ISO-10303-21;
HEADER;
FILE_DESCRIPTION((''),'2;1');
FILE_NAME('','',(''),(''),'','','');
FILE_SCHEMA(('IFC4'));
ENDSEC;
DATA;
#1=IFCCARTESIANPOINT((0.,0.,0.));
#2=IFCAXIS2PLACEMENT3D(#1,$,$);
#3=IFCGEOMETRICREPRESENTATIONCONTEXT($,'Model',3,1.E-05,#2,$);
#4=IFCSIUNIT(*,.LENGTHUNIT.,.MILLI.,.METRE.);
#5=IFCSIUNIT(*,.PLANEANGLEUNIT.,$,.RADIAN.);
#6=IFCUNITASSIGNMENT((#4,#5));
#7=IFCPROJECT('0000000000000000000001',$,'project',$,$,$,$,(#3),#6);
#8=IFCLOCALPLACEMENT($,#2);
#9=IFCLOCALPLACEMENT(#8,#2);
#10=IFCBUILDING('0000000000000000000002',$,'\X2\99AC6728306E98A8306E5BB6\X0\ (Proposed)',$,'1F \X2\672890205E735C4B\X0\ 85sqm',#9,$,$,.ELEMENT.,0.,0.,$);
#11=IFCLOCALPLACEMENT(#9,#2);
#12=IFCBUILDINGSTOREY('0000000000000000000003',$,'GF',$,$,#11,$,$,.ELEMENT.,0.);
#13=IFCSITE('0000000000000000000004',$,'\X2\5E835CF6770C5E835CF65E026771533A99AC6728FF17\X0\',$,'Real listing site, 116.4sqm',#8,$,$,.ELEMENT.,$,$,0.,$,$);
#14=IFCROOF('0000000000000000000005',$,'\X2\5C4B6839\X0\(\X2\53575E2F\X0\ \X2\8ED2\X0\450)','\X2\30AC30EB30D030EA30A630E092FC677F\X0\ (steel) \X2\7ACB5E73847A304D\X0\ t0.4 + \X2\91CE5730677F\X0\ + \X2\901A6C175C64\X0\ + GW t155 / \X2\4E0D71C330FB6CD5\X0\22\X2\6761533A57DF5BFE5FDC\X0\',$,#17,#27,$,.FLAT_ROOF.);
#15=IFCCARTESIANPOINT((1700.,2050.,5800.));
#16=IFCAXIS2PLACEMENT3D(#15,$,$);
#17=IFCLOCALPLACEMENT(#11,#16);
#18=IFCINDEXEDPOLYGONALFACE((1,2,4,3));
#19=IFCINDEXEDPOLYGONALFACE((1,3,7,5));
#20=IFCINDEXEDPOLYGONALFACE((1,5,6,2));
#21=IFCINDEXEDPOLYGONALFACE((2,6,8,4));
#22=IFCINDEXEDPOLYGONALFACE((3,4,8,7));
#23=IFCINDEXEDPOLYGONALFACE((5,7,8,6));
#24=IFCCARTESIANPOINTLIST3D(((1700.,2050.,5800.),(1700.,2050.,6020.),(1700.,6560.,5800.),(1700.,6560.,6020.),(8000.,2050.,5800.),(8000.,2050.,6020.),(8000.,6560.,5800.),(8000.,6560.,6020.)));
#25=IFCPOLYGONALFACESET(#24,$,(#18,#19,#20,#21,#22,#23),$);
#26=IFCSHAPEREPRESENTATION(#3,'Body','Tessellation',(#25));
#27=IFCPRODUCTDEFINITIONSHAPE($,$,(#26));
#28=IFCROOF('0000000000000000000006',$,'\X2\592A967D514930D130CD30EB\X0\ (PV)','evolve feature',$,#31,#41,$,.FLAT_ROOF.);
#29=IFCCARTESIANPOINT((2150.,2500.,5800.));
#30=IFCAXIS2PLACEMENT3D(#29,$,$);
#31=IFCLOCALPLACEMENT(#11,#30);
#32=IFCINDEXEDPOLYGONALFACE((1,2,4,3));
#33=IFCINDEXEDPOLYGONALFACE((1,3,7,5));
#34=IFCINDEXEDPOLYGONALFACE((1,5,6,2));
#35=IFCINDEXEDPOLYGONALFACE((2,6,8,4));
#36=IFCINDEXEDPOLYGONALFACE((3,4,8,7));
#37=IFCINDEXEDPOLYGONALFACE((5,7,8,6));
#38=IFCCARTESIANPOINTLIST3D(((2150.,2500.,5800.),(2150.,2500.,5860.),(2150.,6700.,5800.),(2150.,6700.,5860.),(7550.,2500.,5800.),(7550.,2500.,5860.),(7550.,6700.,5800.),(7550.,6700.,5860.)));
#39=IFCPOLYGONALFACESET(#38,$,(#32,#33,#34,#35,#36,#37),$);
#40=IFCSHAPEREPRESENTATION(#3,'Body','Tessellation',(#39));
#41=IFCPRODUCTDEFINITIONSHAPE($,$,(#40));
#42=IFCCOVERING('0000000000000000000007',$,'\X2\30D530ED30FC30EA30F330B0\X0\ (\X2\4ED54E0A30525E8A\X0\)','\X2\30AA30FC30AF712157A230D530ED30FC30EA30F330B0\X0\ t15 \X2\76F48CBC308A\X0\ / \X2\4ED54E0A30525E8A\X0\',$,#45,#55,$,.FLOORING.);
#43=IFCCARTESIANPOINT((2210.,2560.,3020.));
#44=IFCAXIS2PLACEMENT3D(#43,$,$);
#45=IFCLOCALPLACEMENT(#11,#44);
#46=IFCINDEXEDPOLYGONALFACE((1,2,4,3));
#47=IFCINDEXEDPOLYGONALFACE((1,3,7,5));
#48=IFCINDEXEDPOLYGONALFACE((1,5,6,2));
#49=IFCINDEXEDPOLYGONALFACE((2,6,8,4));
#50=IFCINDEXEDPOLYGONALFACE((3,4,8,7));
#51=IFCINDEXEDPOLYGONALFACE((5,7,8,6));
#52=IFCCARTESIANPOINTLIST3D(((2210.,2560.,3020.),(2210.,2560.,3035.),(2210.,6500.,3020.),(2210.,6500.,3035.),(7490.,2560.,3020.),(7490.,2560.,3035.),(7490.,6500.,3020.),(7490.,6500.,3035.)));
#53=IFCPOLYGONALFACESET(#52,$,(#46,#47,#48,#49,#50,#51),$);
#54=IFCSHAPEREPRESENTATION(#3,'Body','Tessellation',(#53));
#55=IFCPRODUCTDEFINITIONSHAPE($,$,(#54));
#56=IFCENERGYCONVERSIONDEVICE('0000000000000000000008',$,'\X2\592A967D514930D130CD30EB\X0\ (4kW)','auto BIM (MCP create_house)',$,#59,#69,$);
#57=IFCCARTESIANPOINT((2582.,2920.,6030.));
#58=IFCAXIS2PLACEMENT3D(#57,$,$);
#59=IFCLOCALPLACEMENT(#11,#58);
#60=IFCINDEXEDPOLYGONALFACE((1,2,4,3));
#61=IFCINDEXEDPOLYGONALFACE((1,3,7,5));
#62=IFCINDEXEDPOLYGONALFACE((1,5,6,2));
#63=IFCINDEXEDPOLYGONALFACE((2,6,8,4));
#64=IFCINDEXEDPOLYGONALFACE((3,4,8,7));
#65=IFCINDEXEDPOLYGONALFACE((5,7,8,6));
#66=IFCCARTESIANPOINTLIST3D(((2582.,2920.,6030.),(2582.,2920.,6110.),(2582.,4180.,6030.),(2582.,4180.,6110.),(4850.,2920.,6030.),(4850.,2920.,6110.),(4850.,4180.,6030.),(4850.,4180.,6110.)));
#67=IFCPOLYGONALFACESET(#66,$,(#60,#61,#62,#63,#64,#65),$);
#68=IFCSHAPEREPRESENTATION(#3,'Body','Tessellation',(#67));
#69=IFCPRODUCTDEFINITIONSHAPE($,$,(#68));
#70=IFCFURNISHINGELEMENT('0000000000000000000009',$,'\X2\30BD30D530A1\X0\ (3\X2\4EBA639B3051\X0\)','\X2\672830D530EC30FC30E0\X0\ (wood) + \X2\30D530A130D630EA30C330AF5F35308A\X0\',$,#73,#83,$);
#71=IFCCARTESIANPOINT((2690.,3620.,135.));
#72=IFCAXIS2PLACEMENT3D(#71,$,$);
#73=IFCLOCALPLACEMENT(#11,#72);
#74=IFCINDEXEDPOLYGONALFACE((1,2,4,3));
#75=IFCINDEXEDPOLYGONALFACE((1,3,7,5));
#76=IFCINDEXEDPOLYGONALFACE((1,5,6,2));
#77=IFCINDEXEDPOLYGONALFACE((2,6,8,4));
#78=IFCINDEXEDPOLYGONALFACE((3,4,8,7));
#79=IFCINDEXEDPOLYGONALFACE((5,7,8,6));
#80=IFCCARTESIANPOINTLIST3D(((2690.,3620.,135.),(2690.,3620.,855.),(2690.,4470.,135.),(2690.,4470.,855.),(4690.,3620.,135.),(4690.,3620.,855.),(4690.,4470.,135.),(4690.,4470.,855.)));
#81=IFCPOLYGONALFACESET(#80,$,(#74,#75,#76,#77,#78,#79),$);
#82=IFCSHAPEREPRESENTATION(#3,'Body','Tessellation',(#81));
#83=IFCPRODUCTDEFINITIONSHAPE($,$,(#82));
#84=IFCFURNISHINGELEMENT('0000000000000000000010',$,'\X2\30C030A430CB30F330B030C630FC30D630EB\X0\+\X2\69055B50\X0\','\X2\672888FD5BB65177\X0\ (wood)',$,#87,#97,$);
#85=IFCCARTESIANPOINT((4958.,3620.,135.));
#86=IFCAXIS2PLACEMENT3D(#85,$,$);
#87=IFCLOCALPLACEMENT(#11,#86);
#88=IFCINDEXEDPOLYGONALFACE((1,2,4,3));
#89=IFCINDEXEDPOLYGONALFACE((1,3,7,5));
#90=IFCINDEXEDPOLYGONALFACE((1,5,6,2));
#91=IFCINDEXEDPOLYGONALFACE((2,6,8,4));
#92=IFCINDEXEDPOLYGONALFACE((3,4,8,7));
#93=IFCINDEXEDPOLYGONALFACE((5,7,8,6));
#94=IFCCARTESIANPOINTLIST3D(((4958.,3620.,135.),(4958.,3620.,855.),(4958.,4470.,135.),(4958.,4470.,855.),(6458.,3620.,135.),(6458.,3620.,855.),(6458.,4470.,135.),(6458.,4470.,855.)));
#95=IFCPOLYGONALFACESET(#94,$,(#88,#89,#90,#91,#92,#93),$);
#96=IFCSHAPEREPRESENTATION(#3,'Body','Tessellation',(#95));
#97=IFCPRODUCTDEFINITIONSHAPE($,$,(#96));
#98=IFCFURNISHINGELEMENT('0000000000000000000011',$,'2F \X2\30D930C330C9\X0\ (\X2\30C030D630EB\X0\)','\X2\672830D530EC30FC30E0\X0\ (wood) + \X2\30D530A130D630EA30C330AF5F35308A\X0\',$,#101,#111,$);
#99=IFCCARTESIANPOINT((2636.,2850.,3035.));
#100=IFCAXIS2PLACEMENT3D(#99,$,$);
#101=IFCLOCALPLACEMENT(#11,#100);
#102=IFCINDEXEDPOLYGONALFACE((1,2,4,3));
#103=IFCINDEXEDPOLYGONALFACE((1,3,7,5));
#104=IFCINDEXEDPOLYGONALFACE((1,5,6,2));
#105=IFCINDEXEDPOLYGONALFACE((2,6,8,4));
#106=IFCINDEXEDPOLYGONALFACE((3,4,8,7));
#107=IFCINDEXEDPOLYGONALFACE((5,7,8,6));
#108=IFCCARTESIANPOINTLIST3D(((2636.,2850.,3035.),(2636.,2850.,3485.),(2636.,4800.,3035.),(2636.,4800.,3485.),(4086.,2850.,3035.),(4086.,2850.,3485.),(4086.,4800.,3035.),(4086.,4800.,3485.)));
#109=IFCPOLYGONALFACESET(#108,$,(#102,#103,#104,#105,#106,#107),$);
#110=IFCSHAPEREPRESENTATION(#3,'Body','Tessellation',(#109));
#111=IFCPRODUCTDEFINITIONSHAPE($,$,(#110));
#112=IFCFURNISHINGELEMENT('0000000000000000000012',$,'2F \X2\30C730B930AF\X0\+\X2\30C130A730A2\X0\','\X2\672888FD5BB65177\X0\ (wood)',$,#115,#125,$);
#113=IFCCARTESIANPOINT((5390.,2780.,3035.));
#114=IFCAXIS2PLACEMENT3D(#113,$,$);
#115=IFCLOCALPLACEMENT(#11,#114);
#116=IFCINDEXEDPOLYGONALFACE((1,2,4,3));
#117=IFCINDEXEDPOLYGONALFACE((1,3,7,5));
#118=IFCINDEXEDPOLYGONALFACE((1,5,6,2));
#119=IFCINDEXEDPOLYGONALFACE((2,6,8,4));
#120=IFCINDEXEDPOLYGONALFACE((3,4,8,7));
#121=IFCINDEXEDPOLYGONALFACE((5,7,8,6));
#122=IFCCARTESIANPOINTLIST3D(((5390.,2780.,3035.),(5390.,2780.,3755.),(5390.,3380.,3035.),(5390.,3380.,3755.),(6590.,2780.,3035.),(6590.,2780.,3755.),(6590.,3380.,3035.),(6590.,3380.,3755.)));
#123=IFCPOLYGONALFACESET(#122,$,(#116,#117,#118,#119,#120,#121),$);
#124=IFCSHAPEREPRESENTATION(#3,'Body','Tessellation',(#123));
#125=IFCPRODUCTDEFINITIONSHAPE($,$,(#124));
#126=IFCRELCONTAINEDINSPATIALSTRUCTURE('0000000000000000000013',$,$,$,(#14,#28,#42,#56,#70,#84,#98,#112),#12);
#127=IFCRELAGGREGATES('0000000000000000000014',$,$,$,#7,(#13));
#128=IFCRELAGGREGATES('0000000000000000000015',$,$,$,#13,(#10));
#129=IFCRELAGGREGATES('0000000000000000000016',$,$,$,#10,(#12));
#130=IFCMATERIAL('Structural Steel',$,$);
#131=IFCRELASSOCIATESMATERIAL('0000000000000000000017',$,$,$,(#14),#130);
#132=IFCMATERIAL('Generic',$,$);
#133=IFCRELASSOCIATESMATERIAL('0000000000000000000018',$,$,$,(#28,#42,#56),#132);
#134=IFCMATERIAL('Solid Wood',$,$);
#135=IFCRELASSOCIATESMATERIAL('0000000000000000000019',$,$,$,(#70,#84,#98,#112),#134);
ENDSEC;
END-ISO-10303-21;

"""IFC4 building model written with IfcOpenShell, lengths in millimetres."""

from ifc_helpers import new_model, si_unit, frame, frame_2d, origin, place, context, project, spatial, rectangle, extrude, material, element, save


model = new_model("IFC4")

# Units and contexts
model_context = context("Model", 3, precision=1e-05, world=origin())
ifc_project = project(units=[si_unit("LENGTHUNIT", "METRE", prefix="MILLI"), si_unit("PLANEANGLEUNIT", "RADIAN")], contexts=[model_context])

# Site, building, storey
site_placement = place(None, origin())
site = spatial("IfcSite", under=ifc_project, at=site_placement, Name="広島県広島市東区馬木７", ObjectType="Real listing site, 116.4sqm", CompositionType="ELEMENT", RefElevation=0.0)
building_placement = place(site_placement, origin())
building = spatial("IfcBuilding", under=site, at=building_placement, Name="馬木の風の家 (Proposed)", ObjectType="1F 木造平屋 85sqm", CompositionType="ELEMENT", ElevationOfRefHeight=0.0, ElevationOfTerrain=0.0)
storey_placement = place(building_placement, origin())
storey = spatial("IfcBuildingStorey", under=building, at=storey_placement, Name="GF", CompositionType="ELEMENT", Elevation=0.0)

# Shared definitions
ifc_material_1 = material(Name="Solid Wood")

# Shared definitions
ifc_material_2 = material(Name="Generic")

# Roofs
ifc_material_3 = material(Name="Structural Steel")
for number, where, name in (
    (1, (1700.0, 2050.0, 5800.0), "屋根(南帯 軒450)"),
):
    element("IfcRoof", number, at=place(storey_placement, frame(where)), inside=storey, material=ifc_material_3, Name=name, Description="ガルバリウム鋼板 (steel) 立平葺き t0.4 + 野地板 + 通気層 + GW t155 / 不燃・法22条区域対応", PredefinedType="FLAT_ROOF", context=model_context, shape_type="SweptSolid", body=[
        extrude(rectangle(XDim=6300.0, YDim=4510.0, at=frame_2d((3150.0, 2255.0))), frame((1700.0, 2050.0, 5800.0)), (0.0, 0.0, 1.0), 220.0),
    ])
roof_placement = place(storey_placement, frame((2150.0, 2500.0, 5800.0)))
element("IfcRoof", 2, at=roof_placement, inside=storey, material=ifc_material_2, Name="太陽光パネル (PV)", Description="evolve feature", PredefinedType="FLAT_ROOF", context=model_context, shape_type="SweptSolid", body=[
    extrude(rectangle(XDim=5400.0, YDim=4200.0, at=frame_2d((2700.0, 2100.0))), frame((2150.0, 2500.0, 5800.0)), (0.0, 0.0, 1.0), 60.0),
])

# Covering
covering_placement = place(storey_placement, frame((2210.0, 2560.0, 3020.0)))
element("IfcCovering", 3, at=covering_placement, inside=storey, material=ifc_material_2, Name="フローリング (仕上げ床)", Description="オーク無垢フローリング t15 直貼り / 仕上げ床", PredefinedType="FLOORING", context=model_context, shape_type="SweptSolid", body=[
    extrude(rectangle(XDim=5280.0, YDim=3940.0, at=frame_2d((2640.0, 1970.0))), frame((2210.0, 2560.0, 3020.0)), (0.0, 0.0, 1.0), 15.0),
])

# Energy conversion device
energy_conversion_device_placement = place(storey_placement, frame((2582.0, 2920.0, 6030.0)))
element("IfcEnergyConversionDevice", 4, at=energy_conversion_device_placement, inside=storey, material=ifc_material_2, Name="太陽光パネル (4kW)", Description="auto BIM (MCP create_house)", context=model_context, shape_type="SweptSolid", body=[
    extrude(rectangle(XDim=2268.0, YDim=1260.0, at=frame_2d((1134.0, 630.0))), frame((2582.0, 2920.0, 6030.0)), (0.0, 0.0, 1.0), 80.0),
])

# Furnishing elements
furnishing_1_placement = place(storey_placement, frame((2690.0, 3620.0, 135.0)))
element("IfcFurnishingElement", 5, at=furnishing_1_placement, inside=storey, material=ifc_material_1, Name="ソファ (3人掛け)", Description="木フレーム (wood) + ファブリック張り", context=model_context, shape_type="SweptSolid", body=[
    extrude(rectangle(XDim=2000.0, YDim=850.0, at=frame_2d((1000.0, 425.0))), frame((2690.0, 3620.0, 135.0)), (0.0, 0.0, 1.0), 720.0),
])
furnishing_2_placement = place(storey_placement, frame((4958.0, 3620.0, 135.0)))
element("IfcFurnishingElement", 6, at=furnishing_2_placement, inside=storey, material=ifc_material_1, Name="ダイニングテーブル+椅子", Description="木製家具 (wood)", context=model_context, shape_type="SweptSolid", body=[
    extrude(rectangle(XDim=1500.0, YDim=850.0, at=frame_2d((750.0, 425.0))), frame((4958.0, 3620.0, 135.0)), (0.0, 0.0, 1.0), 720.0),
])
furnishing_3_placement = place(storey_placement, frame((2636.0, 2850.0, 3035.0)))
element("IfcFurnishingElement", 7, at=furnishing_3_placement, inside=storey, material=ifc_material_1, Name="2F ベッド (ダブル)", Description="木フレーム (wood) + ファブリック張り", context=model_context, shape_type="SweptSolid", body=[
    extrude(rectangle(XDim=1450.0, YDim=1950.0, at=frame_2d((725.0, 975.0))), frame((2636.0, 2850.0, 3035.0)), (0.0, 0.0, 1.0), 450.0),
])
furnishing_4_placement = place(storey_placement, frame((5390.0, 2780.0, 3035.0)))
element("IfcFurnishingElement", 8, at=furnishing_4_placement, inside=storey, material=ifc_material_1, Name="2F デスク+チェア", Description="木製家具 (wood)", context=model_context, shape_type="SweptSolid", body=[
    extrude(rectangle(XDim=1200.0, YDim=600.0, at=frame_2d((600.0, 300.0))), frame((5390.0, 2780.0, 3035.0)), (0.0, 0.0, 1.0), 720.0),
])

save(model, "model.ifc")
